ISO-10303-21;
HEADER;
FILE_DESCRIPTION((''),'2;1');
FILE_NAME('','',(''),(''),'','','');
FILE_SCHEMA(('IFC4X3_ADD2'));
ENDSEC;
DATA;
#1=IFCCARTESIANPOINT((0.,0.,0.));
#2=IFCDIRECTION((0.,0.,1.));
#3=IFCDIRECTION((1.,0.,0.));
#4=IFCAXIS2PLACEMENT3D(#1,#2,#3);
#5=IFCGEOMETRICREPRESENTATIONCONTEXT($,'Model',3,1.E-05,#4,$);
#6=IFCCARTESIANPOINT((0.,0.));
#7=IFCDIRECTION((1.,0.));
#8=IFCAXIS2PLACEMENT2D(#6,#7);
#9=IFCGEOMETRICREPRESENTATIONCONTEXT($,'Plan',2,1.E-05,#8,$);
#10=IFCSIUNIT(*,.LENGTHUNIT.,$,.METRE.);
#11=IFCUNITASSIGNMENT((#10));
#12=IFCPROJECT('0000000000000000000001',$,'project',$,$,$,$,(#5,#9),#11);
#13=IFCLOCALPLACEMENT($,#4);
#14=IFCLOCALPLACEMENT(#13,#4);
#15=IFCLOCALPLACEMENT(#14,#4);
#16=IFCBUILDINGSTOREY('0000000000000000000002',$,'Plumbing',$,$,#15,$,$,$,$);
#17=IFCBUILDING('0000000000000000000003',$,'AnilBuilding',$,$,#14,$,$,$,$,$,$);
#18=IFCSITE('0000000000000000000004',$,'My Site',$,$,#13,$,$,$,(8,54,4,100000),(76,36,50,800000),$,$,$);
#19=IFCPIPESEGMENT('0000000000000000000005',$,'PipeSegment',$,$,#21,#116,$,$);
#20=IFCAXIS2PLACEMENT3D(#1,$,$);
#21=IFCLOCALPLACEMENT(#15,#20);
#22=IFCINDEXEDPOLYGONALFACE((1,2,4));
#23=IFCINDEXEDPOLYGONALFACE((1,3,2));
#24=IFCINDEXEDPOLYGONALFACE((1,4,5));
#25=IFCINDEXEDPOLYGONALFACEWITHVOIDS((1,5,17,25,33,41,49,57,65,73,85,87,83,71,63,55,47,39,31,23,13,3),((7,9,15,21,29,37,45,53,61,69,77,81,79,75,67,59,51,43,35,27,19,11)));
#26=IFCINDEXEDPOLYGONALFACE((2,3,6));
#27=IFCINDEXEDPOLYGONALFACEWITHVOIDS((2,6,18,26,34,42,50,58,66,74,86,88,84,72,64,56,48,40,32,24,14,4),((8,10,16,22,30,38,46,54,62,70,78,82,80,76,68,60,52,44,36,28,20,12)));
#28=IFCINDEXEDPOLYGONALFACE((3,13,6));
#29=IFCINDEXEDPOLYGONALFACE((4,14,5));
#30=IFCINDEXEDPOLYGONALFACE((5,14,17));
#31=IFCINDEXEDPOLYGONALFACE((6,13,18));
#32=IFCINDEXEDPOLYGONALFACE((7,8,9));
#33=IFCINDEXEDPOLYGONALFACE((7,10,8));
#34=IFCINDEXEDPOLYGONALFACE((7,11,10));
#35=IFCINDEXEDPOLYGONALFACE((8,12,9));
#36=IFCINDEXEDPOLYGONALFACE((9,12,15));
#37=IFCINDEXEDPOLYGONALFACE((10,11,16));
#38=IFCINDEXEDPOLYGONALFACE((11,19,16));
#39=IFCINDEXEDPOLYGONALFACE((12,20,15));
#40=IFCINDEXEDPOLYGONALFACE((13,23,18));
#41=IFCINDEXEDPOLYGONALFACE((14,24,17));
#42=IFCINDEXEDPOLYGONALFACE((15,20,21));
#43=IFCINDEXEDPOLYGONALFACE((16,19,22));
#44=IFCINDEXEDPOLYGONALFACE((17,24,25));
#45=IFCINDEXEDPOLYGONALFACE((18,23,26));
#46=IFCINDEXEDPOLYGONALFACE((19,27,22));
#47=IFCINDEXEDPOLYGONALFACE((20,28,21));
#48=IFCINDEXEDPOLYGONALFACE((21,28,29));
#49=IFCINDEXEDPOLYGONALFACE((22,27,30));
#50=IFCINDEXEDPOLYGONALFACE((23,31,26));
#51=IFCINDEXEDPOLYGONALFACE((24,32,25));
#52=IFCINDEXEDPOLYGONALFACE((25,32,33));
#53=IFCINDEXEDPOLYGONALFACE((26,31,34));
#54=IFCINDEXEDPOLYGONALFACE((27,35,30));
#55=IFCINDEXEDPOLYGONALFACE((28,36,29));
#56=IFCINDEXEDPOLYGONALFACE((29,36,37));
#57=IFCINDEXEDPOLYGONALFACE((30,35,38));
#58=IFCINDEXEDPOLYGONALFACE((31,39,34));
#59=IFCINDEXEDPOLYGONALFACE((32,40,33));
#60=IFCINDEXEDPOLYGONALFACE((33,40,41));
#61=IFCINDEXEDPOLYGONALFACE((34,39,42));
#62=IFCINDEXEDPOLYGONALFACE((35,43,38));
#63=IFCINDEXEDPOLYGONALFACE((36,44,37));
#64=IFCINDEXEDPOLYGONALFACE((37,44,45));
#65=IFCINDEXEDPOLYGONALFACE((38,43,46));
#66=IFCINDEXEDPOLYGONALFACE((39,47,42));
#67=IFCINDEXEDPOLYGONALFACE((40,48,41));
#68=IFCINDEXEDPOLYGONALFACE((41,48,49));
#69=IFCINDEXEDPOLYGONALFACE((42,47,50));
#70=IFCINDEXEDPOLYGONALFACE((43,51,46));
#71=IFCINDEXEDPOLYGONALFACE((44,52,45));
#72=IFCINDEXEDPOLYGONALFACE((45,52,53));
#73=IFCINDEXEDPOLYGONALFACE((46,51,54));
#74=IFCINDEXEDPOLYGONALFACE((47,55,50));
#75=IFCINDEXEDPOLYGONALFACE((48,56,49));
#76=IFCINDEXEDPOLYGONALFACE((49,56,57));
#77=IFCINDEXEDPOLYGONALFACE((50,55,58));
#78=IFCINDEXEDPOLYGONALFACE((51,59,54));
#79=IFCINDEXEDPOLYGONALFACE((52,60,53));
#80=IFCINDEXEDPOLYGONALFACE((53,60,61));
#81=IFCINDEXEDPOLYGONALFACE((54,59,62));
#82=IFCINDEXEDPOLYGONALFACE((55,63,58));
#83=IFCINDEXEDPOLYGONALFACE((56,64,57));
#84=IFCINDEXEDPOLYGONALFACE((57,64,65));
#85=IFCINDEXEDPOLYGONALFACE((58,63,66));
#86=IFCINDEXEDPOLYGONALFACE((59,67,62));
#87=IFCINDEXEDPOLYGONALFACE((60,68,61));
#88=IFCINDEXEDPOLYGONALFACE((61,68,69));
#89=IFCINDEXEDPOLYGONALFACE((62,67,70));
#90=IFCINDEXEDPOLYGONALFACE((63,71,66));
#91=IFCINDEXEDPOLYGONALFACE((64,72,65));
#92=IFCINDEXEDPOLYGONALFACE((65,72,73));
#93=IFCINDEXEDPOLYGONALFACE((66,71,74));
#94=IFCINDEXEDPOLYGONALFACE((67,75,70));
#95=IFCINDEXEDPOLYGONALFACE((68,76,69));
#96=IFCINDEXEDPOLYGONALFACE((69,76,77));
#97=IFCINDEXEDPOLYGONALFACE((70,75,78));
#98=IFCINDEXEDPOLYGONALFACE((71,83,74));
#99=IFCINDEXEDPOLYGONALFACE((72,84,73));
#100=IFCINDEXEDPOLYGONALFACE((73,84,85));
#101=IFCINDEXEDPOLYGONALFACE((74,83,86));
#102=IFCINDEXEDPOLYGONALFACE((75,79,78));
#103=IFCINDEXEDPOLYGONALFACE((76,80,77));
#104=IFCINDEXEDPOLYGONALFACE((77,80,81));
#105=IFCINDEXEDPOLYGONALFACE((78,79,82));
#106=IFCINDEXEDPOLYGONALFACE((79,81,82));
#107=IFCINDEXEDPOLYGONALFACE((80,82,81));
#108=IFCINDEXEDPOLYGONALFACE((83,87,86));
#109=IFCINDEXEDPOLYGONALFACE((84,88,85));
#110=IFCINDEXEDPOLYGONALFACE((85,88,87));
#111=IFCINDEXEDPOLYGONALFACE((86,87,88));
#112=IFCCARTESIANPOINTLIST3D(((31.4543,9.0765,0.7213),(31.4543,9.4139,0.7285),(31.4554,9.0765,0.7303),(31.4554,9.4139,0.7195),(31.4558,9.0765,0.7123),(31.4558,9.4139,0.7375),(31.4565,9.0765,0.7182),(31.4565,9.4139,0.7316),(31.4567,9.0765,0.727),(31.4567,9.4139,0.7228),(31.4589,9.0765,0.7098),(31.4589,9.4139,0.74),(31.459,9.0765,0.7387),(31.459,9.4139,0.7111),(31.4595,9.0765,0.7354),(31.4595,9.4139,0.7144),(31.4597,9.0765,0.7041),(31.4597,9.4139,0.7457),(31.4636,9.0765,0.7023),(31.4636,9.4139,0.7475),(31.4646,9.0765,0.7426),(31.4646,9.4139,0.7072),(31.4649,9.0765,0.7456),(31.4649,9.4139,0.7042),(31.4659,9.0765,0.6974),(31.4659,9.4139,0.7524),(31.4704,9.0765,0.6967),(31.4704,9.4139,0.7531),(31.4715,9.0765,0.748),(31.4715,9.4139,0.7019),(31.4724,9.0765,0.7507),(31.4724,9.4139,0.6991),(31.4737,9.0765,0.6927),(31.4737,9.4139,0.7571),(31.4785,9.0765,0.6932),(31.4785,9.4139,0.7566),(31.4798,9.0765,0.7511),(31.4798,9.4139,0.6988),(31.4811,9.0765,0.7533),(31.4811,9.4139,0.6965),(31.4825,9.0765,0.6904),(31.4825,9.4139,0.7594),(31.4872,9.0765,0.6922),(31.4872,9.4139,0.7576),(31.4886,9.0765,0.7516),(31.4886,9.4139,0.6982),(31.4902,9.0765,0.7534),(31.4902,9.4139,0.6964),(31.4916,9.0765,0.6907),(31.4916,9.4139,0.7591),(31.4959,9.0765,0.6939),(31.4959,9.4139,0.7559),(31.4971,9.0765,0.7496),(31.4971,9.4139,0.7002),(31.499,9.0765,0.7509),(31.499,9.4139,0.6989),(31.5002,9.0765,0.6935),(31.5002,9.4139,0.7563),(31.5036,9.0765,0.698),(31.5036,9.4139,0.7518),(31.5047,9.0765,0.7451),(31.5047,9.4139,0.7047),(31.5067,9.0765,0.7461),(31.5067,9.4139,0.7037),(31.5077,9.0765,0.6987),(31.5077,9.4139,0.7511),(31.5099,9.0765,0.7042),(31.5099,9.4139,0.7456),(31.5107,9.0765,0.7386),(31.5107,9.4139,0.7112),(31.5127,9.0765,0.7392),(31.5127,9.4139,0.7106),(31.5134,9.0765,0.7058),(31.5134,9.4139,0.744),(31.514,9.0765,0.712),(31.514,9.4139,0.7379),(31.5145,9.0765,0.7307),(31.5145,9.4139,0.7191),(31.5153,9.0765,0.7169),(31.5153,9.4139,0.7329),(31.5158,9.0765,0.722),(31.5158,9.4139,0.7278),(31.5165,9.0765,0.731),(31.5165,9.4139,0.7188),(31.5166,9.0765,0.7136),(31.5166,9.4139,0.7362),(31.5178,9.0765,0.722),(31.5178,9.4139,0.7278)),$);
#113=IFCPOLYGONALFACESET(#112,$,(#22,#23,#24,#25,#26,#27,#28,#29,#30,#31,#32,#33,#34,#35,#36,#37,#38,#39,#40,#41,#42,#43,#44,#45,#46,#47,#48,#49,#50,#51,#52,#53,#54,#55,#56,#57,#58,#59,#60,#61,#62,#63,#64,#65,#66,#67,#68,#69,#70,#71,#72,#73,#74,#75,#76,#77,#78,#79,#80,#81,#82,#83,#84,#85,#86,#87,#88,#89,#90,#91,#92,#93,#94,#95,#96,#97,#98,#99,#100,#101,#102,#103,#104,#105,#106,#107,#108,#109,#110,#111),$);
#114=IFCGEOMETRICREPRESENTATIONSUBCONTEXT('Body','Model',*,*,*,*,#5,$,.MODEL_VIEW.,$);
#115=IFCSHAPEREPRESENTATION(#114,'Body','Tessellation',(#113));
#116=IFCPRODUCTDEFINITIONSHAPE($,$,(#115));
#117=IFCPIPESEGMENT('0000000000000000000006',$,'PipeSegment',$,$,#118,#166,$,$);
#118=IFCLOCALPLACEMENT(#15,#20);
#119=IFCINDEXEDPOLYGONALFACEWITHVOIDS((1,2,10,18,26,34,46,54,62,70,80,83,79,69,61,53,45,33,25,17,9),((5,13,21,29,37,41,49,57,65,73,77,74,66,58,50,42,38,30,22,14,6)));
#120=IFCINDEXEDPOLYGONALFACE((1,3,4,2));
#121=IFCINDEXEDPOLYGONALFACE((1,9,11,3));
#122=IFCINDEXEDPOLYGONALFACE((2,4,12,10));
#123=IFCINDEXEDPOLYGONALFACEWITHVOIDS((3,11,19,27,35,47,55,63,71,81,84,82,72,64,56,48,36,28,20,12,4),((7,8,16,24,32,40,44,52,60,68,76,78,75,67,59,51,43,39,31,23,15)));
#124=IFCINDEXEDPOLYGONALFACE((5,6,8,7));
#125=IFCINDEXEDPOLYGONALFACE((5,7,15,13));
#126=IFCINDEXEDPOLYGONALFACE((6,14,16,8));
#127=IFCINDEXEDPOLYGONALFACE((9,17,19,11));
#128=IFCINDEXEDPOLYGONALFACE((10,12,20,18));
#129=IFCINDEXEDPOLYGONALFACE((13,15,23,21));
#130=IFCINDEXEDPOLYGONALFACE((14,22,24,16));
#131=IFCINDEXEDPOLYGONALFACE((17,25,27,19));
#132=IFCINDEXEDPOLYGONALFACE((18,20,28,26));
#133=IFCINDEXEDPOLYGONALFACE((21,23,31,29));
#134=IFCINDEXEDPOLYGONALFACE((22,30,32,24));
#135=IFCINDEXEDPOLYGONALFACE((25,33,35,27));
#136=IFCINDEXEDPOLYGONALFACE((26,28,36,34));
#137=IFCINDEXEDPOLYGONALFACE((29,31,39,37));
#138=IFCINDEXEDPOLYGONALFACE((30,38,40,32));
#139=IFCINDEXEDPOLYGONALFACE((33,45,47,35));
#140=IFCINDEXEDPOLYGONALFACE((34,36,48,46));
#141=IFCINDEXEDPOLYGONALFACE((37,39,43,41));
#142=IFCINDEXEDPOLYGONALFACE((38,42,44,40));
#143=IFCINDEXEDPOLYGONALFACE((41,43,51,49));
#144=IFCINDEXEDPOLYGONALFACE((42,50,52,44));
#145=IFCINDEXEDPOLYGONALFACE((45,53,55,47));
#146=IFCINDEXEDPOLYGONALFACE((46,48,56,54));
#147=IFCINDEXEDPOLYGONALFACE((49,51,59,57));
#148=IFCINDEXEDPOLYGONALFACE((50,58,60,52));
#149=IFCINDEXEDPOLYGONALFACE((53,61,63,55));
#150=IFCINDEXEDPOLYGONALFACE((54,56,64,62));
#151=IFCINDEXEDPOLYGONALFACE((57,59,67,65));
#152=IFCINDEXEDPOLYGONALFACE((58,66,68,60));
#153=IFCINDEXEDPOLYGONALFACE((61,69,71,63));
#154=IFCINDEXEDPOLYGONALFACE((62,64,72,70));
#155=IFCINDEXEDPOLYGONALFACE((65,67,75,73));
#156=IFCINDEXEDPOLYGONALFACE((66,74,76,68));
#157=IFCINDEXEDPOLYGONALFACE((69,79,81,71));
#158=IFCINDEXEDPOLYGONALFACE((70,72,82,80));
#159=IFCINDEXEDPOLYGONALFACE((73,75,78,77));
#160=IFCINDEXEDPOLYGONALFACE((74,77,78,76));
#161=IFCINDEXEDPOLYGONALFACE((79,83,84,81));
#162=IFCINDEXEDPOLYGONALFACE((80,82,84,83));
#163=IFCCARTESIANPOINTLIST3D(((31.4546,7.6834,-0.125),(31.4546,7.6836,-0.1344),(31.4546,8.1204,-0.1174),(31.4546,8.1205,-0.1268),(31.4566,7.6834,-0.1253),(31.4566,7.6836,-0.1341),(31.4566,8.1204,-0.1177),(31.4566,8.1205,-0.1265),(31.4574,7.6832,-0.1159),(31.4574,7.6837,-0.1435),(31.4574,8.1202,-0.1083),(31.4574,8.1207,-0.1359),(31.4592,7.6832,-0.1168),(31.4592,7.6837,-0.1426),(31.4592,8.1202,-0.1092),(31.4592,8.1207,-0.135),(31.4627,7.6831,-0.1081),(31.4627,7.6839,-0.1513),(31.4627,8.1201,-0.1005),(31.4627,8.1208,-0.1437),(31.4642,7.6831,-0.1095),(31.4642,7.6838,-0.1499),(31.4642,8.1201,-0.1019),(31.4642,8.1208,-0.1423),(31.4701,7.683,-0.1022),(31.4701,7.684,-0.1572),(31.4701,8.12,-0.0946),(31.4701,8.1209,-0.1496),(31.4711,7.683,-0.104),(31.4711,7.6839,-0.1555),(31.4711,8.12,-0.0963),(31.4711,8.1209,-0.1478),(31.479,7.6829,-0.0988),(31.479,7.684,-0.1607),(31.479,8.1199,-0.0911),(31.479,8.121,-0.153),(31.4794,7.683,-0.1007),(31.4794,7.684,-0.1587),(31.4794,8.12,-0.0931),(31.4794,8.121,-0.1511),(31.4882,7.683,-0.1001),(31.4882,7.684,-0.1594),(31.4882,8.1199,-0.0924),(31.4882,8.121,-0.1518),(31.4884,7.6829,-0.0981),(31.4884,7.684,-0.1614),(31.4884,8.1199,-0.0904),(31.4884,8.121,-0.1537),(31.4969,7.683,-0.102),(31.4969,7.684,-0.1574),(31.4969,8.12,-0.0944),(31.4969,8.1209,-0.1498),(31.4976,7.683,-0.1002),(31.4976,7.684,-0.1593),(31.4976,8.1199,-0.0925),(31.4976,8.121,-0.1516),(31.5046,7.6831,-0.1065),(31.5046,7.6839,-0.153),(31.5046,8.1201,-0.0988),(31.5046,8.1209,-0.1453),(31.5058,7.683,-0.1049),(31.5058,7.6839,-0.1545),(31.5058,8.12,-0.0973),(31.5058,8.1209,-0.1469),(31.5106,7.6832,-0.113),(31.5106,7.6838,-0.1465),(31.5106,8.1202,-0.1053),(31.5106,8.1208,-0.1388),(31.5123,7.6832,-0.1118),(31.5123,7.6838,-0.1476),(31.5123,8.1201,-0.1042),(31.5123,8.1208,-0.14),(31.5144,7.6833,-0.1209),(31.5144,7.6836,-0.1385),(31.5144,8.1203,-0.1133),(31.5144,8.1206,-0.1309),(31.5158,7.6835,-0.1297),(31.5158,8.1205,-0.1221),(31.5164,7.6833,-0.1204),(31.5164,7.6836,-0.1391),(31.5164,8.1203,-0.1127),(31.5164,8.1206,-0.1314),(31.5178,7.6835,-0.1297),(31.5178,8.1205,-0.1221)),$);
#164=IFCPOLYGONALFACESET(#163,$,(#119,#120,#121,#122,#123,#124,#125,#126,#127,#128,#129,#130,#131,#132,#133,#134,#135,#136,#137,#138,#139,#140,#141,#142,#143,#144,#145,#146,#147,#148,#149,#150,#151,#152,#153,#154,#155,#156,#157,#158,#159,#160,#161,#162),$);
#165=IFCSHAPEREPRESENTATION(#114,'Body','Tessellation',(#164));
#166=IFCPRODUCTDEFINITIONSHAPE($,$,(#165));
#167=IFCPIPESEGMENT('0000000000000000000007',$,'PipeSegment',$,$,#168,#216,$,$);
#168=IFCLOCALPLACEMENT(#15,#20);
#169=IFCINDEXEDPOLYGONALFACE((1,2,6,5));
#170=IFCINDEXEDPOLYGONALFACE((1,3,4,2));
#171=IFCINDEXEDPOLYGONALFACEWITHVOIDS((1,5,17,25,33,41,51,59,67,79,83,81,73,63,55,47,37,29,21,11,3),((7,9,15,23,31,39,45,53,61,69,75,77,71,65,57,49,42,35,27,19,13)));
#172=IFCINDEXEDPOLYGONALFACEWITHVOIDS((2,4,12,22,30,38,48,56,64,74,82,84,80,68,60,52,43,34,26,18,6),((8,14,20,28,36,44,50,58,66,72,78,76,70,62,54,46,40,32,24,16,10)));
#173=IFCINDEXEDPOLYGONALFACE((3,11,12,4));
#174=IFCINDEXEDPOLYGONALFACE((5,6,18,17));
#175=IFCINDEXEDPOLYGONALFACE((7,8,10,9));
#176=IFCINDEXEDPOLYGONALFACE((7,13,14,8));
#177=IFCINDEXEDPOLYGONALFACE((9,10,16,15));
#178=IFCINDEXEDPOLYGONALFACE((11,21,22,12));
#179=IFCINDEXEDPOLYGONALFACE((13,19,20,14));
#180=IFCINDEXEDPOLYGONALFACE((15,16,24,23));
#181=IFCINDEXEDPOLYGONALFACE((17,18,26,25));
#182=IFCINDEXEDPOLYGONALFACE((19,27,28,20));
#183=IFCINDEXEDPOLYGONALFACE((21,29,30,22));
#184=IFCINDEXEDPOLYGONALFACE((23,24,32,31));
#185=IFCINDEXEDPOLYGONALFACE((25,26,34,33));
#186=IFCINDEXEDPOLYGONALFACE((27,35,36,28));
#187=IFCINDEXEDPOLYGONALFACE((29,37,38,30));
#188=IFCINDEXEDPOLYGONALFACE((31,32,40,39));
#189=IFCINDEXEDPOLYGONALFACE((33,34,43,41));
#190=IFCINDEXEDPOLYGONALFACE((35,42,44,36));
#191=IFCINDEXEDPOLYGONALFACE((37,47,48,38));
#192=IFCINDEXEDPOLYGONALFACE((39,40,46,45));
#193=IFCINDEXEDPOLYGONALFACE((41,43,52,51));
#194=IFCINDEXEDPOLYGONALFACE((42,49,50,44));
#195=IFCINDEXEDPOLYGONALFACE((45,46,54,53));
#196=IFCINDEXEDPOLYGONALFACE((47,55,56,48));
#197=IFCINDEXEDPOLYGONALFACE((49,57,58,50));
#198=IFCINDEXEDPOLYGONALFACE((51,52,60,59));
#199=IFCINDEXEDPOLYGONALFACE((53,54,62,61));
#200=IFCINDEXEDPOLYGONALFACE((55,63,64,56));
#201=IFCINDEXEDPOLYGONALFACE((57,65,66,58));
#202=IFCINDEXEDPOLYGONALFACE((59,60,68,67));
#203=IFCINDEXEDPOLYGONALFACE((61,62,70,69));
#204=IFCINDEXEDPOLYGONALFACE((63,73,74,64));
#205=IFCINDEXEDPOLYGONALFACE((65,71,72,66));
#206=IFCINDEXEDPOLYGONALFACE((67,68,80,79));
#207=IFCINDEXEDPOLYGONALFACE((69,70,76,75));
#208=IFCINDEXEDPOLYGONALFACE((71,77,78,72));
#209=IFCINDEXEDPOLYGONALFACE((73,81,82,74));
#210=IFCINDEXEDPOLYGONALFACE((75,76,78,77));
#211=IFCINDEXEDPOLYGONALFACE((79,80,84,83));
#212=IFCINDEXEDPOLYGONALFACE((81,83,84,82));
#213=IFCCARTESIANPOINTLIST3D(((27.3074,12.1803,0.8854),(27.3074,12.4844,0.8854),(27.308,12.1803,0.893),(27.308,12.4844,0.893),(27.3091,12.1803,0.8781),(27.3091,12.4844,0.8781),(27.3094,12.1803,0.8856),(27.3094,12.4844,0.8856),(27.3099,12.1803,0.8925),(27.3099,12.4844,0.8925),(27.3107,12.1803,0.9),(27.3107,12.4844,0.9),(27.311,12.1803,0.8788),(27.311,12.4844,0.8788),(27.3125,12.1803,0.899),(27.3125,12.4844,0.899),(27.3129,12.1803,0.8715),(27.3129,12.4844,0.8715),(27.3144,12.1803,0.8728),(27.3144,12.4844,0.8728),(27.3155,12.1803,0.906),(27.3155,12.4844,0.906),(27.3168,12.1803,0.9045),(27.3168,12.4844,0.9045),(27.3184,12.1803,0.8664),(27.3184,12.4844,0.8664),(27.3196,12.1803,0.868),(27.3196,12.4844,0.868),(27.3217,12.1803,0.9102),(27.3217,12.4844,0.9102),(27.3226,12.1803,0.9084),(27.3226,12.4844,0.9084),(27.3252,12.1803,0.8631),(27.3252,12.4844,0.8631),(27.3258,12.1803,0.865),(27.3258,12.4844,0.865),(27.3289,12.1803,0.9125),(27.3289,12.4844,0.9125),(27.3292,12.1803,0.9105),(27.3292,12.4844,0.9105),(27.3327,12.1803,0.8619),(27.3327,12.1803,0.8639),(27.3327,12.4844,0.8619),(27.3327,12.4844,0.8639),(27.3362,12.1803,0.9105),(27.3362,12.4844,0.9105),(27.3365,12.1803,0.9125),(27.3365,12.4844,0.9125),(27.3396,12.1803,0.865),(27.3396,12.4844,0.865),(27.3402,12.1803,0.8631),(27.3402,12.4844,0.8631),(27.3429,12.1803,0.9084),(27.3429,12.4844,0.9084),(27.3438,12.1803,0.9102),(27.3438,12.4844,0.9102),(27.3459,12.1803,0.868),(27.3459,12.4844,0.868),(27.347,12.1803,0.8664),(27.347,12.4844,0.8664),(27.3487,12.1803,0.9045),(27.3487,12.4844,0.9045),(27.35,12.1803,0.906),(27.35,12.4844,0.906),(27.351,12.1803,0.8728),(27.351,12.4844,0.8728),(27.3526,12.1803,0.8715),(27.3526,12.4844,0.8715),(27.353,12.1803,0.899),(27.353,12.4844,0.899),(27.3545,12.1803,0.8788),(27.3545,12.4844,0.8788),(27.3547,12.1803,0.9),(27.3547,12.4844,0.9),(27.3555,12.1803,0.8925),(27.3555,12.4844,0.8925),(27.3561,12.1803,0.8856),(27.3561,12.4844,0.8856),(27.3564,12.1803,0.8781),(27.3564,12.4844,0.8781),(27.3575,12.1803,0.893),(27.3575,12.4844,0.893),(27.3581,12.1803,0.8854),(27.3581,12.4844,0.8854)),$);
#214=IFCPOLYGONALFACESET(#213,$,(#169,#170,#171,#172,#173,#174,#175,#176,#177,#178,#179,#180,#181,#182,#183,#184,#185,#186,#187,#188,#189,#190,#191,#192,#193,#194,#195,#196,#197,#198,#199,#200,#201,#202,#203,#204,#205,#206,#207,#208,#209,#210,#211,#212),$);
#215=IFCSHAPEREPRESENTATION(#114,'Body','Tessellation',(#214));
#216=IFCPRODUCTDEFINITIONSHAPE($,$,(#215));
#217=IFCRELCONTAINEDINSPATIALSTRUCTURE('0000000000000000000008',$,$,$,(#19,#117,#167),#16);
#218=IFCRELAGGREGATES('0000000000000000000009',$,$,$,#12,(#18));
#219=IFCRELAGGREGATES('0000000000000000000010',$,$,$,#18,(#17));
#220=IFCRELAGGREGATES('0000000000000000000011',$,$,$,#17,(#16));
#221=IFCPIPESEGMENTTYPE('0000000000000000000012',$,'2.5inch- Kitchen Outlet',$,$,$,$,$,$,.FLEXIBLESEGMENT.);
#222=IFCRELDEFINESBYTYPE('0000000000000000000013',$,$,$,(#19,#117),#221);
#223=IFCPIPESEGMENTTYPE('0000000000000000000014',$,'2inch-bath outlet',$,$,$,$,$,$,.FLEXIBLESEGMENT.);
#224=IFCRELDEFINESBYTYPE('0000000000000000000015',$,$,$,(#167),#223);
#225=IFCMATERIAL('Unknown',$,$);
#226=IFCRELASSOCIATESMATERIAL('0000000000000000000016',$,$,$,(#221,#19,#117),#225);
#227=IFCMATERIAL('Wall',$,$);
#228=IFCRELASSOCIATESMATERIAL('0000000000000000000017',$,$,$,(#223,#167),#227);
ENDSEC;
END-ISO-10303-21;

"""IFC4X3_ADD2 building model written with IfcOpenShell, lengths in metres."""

from ifc_helpers import new_model, si_unit, frame, origin_with_axes, origin_2d_with_axis, place, context, subcontext, project, spatial, hollow_circle, extrude, clip, halfspace, material, material_profile, profile_set, profile_usage, type_object, element, save


model = new_model("IFC4X3_ADD2")

# Units and contexts
model_context = context("Model", 3, precision=1e-05, world=origin_with_axes())
plan_context = context("Plan", 2, precision=1e-05, world=origin_2d_with_axis())
body_context = subcontext(model_context, "Body", "Model", "MODEL_VIEW")
ifc_project = project(units=[si_unit("LENGTHUNIT", "METRE")], contexts=[model_context, plan_context])

# Site, building, storey
site_placement = place(None, origin_with_axes())
site = spatial("IfcSite", under=ifc_project, at=site_placement, Name="My Site", RefLatitude=(8, 54, 4, 100000), RefLongitude=(76, 36, 50, 800000))
building_placement = place(site_placement, origin_with_axes())
building = spatial("IfcBuilding", under=site, at=building_placement, Name="AnilBuilding")
storey_placement = place(building_placement, origin_with_axes())
storey = spatial("IfcBuildingStorey", under=building, at=storey_placement, Name="Plumbing")

# Pipe segments
ifc_material_1 = material(Name="Unknown")
ifc_material_profile_1 = material_profile(ifc_material_1, hollow_circle(Radius=0.0318, WallThickness=0.002))
ifc_profile_set_1 = profile_set([ifc_material_profile_1], Name="kitchenwater")
pipe_segment_type_1 = type_object("IfcPipeSegmentType", Name="2.5inch- Kitchen Outlet", PredefinedType="FLEXIBLESEGMENT", material=ifc_profile_set_1)
ifc_profile_usage_1 = profile_usage(ifc_profile_set_1)
pipe_segment_1_placement = place(storey_placement, frame((31.486, 9.4773, 0.729), z_axis=(0.0, -0.999848, -0.017452), x_axis=(1.0, 0.0, 0.0)))
element("IfcPipeSegment", 1, at=pipe_segment_1_placement, inside=storey, type_object=pipe_segment_type_1, material=ifc_profile_usage_1, Name="PipeSegment", context=body_context, shape_type="Clipping", body=[
    clip(clip(extrude(hollow_circle(Radius=0.0318, WallThickness=0.002), origin_with_axes(), (0.0, 0.0, 1.0), 0.4642), halfspace(frame((0.0, -0.0946, 0.0651), z_axis=(0.0, -0.017452, -0.999848), x_axis=(-1.0, 0.000005, 0.0)), False)), halfspace(frame((0.0, -0.9386, 0.4172), z_axis=(0.0, 0.017452, 0.999848), x_axis=(1.0, -0.000005, 0.0)), False)),
])
ifc_profile_usage_2 = profile_usage(ifc_profile_set_1)
pipe_segment_2_placement = place(storey_placement, frame((31.486, 8.1205, -0.1221), z_axis=(0.0, -0.999848, -0.017452), x_axis=(1.0, 0.0, 0.0)))
element("IfcPipeSegment", 2, at=pipe_segment_2_placement, inside=storey, type_object=pipe_segment_type_1, material=ifc_profile_usage_2, Name="PipeSegment", context=body_context, shape_type="SweptSolid", body=[
    extrude(hollow_circle(Radius=0.0318, WallThickness=0.002), origin_with_axes(), (0.0, 0.0, 1.0), 0.4371),
])
ifc_material_2 = material(Name="Wall")
ifc_material_profile_2 = material_profile(ifc_material_2, hollow_circle(Radius=0.0254, WallThickness=0.002))
ifc_profile_set_2 = profile_set([ifc_material_profile_2], Name="graywater")
ifc_profile_usage_3 = profile_usage(ifc_profile_set_2, cardinal=5)
pipe_segment_type_2 = type_object("IfcPipeSegmentType", Name="2inch-bath outlet", PredefinedType="FLEXIBLESEGMENT", material=ifc_profile_set_2)
pipe_segment_3_placement = place(storey_placement, frame((27.3327, 12.1803, 0.8873), z_axis=(0.0, 1.0, 0.0), x_axis=(0.0, 0.0, -1.0)))
element("IfcPipeSegment", 3, at=pipe_segment_3_placement, inside=storey, type_object=pipe_segment_type_2, material=ifc_profile_usage_3, Name="PipeSegment", context=body_context, shape_type="SweptSolid", body=[
    extrude(hollow_circle(Radius=0.0254, WallThickness=0.002), origin_with_axes(), (0.0, 0.0, 1.0), 0.3041),
])

save(model, "model.ifc")
